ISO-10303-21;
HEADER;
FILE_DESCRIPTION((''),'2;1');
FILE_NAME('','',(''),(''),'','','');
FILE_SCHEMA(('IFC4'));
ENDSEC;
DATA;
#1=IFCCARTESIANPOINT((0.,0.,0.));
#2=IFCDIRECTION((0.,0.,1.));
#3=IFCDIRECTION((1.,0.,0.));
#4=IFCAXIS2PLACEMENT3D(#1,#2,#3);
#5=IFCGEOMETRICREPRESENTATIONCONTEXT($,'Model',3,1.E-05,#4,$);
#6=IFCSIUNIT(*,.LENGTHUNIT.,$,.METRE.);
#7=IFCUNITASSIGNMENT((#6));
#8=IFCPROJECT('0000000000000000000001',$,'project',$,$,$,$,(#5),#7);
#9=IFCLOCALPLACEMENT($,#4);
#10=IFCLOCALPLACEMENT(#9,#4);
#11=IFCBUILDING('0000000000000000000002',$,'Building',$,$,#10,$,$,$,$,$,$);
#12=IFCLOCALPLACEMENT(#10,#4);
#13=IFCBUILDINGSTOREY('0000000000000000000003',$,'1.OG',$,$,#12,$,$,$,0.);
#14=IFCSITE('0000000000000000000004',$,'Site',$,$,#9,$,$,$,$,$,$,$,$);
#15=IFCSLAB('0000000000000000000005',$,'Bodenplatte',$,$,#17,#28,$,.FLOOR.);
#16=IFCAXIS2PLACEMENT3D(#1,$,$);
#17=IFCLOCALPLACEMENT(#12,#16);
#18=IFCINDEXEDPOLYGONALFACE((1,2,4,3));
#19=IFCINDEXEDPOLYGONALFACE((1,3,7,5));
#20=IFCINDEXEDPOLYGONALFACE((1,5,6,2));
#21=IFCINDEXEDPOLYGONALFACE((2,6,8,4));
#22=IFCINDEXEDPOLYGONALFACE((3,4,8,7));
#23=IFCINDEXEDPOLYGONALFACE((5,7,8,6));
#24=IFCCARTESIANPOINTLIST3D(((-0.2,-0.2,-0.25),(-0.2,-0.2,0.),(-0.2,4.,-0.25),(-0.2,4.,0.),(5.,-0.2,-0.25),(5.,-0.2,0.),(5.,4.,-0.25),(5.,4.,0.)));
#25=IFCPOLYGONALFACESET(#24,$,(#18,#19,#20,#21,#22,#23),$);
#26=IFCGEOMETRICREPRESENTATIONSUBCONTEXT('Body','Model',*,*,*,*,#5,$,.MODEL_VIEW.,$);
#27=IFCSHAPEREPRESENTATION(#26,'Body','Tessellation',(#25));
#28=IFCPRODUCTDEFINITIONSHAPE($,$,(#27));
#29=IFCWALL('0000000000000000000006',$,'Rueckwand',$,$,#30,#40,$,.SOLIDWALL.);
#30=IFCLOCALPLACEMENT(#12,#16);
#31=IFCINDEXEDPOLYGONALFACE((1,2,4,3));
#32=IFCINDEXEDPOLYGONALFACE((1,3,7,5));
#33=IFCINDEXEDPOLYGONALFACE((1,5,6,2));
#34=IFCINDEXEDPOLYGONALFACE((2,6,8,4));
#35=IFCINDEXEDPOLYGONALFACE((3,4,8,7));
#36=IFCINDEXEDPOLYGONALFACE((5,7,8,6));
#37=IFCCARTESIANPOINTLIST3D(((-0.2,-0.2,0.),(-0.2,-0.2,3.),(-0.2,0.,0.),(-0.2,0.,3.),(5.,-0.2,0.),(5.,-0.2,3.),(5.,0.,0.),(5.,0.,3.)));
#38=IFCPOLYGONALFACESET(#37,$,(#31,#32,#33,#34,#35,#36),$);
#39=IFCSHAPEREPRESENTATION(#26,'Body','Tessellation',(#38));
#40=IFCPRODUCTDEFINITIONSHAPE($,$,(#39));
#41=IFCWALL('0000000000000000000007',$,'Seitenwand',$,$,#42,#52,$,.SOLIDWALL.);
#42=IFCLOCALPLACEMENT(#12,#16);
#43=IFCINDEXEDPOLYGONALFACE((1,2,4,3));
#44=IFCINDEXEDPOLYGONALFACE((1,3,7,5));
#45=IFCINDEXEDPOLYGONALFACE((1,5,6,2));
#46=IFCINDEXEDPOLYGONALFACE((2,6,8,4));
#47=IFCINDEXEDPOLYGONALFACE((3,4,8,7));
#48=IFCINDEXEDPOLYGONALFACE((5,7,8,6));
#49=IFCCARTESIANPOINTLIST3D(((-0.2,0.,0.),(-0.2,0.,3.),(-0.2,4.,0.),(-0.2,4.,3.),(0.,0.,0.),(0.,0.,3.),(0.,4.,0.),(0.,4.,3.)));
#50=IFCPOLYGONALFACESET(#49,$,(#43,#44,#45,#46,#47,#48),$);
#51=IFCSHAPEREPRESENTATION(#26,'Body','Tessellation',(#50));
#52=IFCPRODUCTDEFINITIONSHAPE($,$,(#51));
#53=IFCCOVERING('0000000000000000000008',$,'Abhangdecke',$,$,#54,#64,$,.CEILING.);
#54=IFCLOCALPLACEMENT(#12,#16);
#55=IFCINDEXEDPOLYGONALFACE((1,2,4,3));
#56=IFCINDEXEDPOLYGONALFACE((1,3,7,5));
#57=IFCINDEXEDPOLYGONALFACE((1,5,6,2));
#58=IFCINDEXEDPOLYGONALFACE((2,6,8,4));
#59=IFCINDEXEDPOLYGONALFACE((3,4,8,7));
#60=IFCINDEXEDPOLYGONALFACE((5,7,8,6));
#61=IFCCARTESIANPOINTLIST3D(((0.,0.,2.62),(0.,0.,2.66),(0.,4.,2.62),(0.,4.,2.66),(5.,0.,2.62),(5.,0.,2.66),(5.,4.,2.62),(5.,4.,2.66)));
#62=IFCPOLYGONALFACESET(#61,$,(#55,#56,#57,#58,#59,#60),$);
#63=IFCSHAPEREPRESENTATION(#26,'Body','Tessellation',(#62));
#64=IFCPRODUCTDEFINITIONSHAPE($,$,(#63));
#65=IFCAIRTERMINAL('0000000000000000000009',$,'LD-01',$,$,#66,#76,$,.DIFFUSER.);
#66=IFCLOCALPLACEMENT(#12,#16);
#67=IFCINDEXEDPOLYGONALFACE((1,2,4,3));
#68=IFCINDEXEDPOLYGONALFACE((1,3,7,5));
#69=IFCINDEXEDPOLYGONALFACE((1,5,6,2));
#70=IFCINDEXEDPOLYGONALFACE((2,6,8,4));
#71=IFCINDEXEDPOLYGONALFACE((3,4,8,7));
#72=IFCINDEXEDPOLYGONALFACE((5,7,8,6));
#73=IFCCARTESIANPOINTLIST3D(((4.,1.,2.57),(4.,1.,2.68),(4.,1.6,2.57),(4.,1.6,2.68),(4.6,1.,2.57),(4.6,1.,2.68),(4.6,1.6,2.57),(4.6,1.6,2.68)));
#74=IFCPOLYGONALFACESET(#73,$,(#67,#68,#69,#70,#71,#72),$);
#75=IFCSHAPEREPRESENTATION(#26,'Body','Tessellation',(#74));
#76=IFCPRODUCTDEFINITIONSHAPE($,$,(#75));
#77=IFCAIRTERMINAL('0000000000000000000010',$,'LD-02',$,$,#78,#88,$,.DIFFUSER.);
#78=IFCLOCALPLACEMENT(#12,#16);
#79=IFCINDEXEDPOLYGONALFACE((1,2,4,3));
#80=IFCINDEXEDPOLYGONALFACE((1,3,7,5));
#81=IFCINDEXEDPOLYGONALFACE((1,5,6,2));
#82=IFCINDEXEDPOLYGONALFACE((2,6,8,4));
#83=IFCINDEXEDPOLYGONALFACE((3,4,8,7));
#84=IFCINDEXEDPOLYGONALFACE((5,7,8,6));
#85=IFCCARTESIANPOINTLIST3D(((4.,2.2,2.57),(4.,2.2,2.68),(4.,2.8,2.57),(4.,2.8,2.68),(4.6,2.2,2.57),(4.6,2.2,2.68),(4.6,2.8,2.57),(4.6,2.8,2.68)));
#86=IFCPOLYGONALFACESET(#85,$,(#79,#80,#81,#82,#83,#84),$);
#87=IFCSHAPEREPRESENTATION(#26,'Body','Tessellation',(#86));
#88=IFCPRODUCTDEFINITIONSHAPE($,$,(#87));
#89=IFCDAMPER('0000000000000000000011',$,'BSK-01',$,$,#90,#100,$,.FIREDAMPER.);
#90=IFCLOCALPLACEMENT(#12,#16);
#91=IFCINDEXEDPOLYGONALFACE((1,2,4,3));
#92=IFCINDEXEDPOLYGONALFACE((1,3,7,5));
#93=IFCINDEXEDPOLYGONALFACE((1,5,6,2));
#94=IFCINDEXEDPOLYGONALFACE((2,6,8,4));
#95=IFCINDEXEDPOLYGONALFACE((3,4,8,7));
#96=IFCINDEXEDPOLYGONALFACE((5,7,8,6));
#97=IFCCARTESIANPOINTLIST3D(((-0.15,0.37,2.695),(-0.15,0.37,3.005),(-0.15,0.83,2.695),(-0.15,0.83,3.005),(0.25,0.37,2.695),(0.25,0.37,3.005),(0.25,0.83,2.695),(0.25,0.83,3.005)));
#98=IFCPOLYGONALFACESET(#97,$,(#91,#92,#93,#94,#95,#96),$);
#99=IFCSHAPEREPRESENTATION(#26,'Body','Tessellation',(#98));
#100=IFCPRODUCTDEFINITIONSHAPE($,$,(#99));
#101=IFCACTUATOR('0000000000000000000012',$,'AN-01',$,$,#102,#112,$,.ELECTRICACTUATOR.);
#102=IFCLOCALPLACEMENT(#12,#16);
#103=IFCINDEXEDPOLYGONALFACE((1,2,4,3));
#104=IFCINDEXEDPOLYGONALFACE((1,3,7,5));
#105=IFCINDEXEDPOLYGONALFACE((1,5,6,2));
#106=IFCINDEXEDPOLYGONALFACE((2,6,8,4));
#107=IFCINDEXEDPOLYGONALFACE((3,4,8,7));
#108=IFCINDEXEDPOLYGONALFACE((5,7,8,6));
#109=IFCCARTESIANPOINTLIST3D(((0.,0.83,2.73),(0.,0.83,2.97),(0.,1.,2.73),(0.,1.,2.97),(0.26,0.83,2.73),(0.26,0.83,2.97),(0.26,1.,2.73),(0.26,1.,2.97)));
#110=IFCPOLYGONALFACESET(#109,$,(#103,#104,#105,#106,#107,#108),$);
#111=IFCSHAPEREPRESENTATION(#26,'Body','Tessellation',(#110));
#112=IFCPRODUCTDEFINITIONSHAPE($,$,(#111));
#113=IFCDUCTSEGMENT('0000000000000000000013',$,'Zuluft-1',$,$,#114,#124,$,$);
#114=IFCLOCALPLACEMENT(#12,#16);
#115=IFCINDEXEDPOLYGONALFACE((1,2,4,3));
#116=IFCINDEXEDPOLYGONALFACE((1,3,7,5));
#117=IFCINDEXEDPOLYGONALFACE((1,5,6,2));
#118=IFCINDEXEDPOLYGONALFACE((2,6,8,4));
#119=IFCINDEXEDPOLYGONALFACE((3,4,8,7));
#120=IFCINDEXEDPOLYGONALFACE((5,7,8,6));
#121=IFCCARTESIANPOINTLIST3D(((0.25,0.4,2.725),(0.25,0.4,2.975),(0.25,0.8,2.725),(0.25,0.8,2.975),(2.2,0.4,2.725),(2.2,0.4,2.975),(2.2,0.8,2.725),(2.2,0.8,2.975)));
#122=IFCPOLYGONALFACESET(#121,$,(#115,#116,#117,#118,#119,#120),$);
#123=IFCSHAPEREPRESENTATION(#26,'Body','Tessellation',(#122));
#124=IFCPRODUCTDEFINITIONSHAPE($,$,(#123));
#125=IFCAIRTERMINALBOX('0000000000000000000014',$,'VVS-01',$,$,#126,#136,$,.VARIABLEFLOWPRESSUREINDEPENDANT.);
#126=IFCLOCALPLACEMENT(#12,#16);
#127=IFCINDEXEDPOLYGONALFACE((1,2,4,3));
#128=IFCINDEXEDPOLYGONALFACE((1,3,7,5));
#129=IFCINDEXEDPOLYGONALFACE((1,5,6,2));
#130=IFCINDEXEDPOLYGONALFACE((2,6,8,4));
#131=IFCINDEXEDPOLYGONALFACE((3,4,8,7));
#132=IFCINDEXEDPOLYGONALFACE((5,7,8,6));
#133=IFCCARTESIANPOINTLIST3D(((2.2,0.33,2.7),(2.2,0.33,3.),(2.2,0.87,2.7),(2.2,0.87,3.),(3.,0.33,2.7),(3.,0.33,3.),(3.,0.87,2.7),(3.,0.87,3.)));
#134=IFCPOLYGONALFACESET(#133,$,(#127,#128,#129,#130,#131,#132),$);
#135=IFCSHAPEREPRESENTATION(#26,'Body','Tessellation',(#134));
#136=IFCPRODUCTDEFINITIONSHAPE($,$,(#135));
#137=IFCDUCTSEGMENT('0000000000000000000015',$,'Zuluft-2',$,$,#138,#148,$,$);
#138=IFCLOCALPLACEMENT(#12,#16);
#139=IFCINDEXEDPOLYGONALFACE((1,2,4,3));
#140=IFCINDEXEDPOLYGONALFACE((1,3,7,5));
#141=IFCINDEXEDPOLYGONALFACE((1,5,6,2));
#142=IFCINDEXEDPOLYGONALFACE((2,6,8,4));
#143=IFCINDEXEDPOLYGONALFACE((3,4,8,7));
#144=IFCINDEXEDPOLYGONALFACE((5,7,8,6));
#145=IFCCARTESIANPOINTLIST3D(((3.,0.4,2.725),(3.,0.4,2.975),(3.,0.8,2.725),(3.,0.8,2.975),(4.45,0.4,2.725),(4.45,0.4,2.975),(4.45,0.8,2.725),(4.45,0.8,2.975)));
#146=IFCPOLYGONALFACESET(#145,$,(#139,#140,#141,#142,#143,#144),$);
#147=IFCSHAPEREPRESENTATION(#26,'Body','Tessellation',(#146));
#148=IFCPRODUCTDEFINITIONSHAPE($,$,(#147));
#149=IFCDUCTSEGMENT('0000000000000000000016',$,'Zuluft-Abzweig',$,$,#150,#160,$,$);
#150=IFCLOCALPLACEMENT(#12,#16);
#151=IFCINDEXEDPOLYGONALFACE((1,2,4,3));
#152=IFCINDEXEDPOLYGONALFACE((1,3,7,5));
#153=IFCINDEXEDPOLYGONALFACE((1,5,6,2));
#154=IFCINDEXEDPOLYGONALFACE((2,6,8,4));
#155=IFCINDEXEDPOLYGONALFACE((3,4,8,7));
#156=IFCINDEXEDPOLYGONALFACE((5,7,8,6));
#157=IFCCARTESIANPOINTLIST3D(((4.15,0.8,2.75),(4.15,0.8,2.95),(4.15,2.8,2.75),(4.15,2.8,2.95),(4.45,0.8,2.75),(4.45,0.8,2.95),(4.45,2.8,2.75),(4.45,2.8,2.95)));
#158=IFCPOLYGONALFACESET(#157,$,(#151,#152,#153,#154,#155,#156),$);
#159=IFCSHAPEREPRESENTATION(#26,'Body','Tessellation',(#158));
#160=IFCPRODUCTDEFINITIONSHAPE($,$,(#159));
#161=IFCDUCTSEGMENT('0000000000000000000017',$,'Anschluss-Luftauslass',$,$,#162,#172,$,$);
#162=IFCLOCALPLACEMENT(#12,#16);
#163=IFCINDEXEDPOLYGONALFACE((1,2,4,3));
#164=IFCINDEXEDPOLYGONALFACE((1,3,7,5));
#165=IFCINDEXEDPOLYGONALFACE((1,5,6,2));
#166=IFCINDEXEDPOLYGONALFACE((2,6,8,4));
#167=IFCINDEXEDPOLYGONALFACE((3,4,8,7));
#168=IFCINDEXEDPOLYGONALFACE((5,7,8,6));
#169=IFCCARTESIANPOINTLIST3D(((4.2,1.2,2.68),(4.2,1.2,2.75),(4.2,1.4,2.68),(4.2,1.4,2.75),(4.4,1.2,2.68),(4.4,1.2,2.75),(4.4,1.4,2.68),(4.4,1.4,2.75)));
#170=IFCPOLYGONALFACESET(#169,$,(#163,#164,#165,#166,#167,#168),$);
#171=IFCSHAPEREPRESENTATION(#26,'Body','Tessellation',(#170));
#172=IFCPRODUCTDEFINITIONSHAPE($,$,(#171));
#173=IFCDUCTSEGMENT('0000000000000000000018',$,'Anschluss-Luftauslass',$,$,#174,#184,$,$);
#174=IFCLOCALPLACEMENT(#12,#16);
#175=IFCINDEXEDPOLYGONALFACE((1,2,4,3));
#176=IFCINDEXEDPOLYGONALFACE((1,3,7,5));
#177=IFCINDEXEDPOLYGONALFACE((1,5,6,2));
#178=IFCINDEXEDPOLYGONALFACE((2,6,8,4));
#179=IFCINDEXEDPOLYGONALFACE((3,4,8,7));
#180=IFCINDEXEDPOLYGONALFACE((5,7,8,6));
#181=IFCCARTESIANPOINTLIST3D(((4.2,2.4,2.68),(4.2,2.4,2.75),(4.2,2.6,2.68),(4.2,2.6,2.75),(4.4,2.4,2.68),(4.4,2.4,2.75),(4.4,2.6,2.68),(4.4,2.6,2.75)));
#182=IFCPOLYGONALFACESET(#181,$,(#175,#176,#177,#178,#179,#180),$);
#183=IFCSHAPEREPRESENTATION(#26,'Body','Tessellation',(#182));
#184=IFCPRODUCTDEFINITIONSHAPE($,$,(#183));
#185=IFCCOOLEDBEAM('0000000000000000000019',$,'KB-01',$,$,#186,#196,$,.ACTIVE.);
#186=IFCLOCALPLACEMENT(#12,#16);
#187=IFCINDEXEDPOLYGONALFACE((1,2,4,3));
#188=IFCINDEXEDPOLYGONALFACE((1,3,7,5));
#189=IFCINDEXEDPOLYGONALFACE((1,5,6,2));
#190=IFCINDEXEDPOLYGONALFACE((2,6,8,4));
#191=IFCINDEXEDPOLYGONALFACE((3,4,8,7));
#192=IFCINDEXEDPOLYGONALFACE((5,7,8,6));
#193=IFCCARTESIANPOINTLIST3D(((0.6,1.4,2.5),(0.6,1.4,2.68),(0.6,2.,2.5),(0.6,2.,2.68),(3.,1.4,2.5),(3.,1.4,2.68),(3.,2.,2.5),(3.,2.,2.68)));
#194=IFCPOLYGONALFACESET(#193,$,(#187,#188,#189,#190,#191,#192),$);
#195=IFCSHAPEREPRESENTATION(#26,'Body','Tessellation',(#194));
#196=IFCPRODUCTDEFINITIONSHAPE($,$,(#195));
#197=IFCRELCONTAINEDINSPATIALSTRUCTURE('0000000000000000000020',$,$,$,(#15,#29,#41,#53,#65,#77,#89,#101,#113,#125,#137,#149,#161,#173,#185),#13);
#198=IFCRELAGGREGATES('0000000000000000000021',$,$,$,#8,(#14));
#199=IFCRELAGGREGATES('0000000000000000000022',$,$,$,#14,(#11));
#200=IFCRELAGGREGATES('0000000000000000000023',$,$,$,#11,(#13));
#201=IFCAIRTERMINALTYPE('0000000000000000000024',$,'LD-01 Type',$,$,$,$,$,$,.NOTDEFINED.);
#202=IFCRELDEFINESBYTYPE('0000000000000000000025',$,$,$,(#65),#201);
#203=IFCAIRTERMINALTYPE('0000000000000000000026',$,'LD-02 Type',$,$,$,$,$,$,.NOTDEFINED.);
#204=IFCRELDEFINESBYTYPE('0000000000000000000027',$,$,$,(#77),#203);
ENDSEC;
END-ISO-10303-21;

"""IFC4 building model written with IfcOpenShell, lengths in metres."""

from ifc_helpers import new_model, si_unit, frame, origin_with_axes, place, context, subcontext, project, spatial, polyline, outline, extrude, type_object, element, save


model = new_model("IFC4")

# Units and contexts
model_context = context("Model", 3, precision=1e-05, world=origin_with_axes())
body_context = subcontext(model_context, "Body", "Model", "MODEL_VIEW")
ifc_project = project(units=[si_unit("LENGTHUNIT", "METRE")], contexts=[model_context])

# Site, building, storey
site_placement = place(None, origin_with_axes())
site = spatial("IfcSite", under=ifc_project, at=site_placement, Name="Site")
building_placement = place(site_placement, origin_with_axes())
building = spatial("IfcBuilding", under=site, at=building_placement, Name="Building")
storey_placement = place(building_placement, origin_with_axes())
storey = spatial("IfcBuildingStorey", under=building, at=storey_placement, Name="1.OG", Elevation=0.0)

# Slab
slab_placement = place(storey_placement, frame((0.0, 0.0, -0.25), z_axis=(0.0, 0.0, 1.0), x_axis=(1.0, 0.0, 0.0)))
element("IfcSlab", 1, at=slab_placement, inside=storey, Name="Bodenplatte", PredefinedType="FLOOR", context=body_context, shape_type="SweptSolid", body=[
    extrude(outline(polyline([(-0.2, -0.2, 0.0), (5.0, -0.2, 0.0), (5.0, 4.0, 0.0), (-0.2, 4.0, 0.0), (-0.2, -0.2, 0.0)])), origin_with_axes(), (0.0, 0.0, 1.0), 0.25),
])

# Walls
wall_1_placement = place(storey_placement, frame((-0.2, -0.2, 0.0), z_axis=(0.0, 0.0, 1.0), x_axis=(1.0, 0.0, 0.0)))
element("IfcWall", 2, at=wall_1_placement, inside=storey, Name="Rueckwand", PredefinedType="SOLIDWALL", context=body_context, shape_type="SweptSolid", body=[
    extrude(outline(polyline([(0.0, 0.0, 0.0), (5.2, 0.0, 0.0), (5.2, 0.2, 0.0), (0.0, 0.2, 0.0), (0.0, 0.0, 0.0)])), origin_with_axes(), (0.0, 0.0, 1.0), 3.0),
])
wall_2_placement = place(storey_placement, frame((0.0, 0.0, 0.0), z_axis=(0.0, 0.0, 1.0), x_axis=(0.0, 1.0, 0.0)))
element("IfcWall", 3, at=wall_2_placement, inside=storey, Name="Seitenwand", PredefinedType="SOLIDWALL", context=body_context, shape_type="SweptSolid", body=[
    extrude(outline(polyline([(0.0, 0.0, 0.0), (4.0, 0.0, 0.0), (4.0, 0.2, 0.0), (0.0, 0.2, 0.0), (0.0, 0.0, 0.0)])), origin_with_axes(), (0.0, 0.0, 1.0), 3.0),
])

# Covering
covering_placement = place(storey_placement, frame((0.0, 0.0, 2.62), z_axis=(0.0, 0.0, 1.0), x_axis=(1.0, 0.0, 0.0)))
element("IfcCovering", 4, at=covering_placement, inside=storey, Name="Abhangdecke", PredefinedType="CEILING", context=body_context, shape_type="SweptSolid", body=[
    extrude(outline(polyline([(0.0, 0.0, 0.0), (5.0, 0.0, 0.0), (5.0, 4.0, 0.0), (0.0, 4.0, 0.0), (0.0, 0.0, 0.0)])), origin_with_axes(), (0.0, 0.0, 1.0), 0.04),
])

# Air terminals
air_terminal_type_1 = type_object("IfcAirTerminalType", Name="LD-01 Type", PredefinedType="NOTDEFINED")
air_terminal_1_placement = place(storey_placement, origin_with_axes())
element("IfcAirTerminal", 5, at=air_terminal_1_placement, inside=storey, type_object=air_terminal_type_1, Name="LD-01", PredefinedType="DIFFUSER", context=body_context, shape_type="SweptSolid", body=[
    extrude(outline(polyline([(4.0, 1.0, 0.0), (4.6, 1.0, 0.0), (4.6, 1.6, 0.0), (4.0, 1.6, 0.0), (4.0, 1.0, 0.0)])), frame((0.0, 0.0, 2.57), z_axis=(0.0, 0.0, 1.0), x_axis=(1.0, 0.0, 0.0)), (0.0, 0.0, 1.0), 0.11),
])
air_terminal_type_2 = type_object("IfcAirTerminalType", Name="LD-02 Type", PredefinedType="NOTDEFINED")
air_terminal_2_placement = place(storey_placement, origin_with_axes())
element("IfcAirTerminal", 6, at=air_terminal_2_placement, inside=storey, type_object=air_terminal_type_2, Name="LD-02", PredefinedType="DIFFUSER", context=body_context, shape_type="SweptSolid", body=[
    extrude(outline(polyline([(4.0, 2.2, 0.0), (4.6, 2.2, 0.0), (4.6, 2.8, 0.0), (4.0, 2.8, 0.0), (4.0, 2.2, 0.0)])), frame((0.0, 0.0, 2.57), z_axis=(0.0, 0.0, 1.0), x_axis=(1.0, 0.0, 0.0)), (0.0, 0.0, 1.0), 0.11),
])

# Damper
damper_placement = place(storey_placement, origin_with_axes())
element("IfcDamper", 7, at=damper_placement, inside=storey, Name="BSK-01", PredefinedType="FIREDAMPER", context=body_context, shape_type="SweptSolid", body=[
    extrude(outline(polyline([(-0.15, 0.37, 0.0), (0.25, 0.37, 0.0), (0.25, 0.83, 0.0), (-0.15, 0.83, 0.0), (-0.15, 0.37, 0.0)])), frame((0.0, 0.0, 2.695), z_axis=(0.0, 0.0, 1.0), x_axis=(1.0, 0.0, 0.0)), (0.0, 0.0, 1.0), 0.31),
])

# Actuator
actuator_placement = place(storey_placement, origin_with_axes())
element("IfcActuator", 8, at=actuator_placement, inside=storey, Name="AN-01", PredefinedType="ELECTRICACTUATOR", context=body_context, shape_type="SweptSolid", body=[
    extrude(outline(polyline([(0.0, 0.83, 0.0), (0.26, 0.83, 0.0), (0.26, 1.0, 0.0), (0.0, 1.0, 0.0), (0.0, 0.83, 0.0)])), frame((0.0, 0.0, 2.73), z_axis=(0.0, 0.0, 1.0), x_axis=(1.0, 0.0, 0.0)), (0.0, 0.0, 1.0), 0.24),
])

# Duct segment
duct_segment_1_placement = place(storey_placement, origin_with_axes())
element("IfcDuctSegment", 9, at=duct_segment_1_placement, inside=storey, Name="Zuluft-1", context=body_context, shape_type="SweptSolid", body=[
    extrude(outline(polyline([(-0.2, -0.125, 0.0), (0.2, -0.125, 0.0), (0.2, 0.125, 0.0), (-0.2, 0.125, 0.0), (-0.2, -0.125, 0.0)])), frame((0.25, 0.6, 2.85), z_axis=(1.0, 0.0, 0.0), x_axis=(0.0, 1.0, 0.0)), (0.0, 0.0, 1.0), 1.95),
])

# Air terminal box
air_terminal_box_placement = place(storey_placement, origin_with_axes())
element("IfcAirTerminalBox", 10, at=air_terminal_box_placement, inside=storey, Name="VVS-01", PredefinedType="VARIABLEFLOWPRESSUREINDEPENDANT", context=body_context, shape_type="SweptSolid", body=[
    extrude(outline(polyline([(2.2, 0.33, 0.0), (3.0, 0.33, 0.0), (3.0, 0.87, 0.0), (2.2, 0.87, 0.0), (2.2, 0.33, 0.0)])), frame((0.0, 0.0, 2.7), z_axis=(0.0, 0.0, 1.0), x_axis=(1.0, 0.0, 0.0)), (0.0, 0.0, 1.0), 0.3),
])

# Duct segments
duct_segment_2_placement = place(storey_placement, origin_with_axes())
element("IfcDuctSegment", 11, at=duct_segment_2_placement, inside=storey, Name="Zuluft-2", context=body_context, shape_type="SweptSolid", body=[
    extrude(outline(polyline([(-0.2, -0.125, 0.0), (0.2, -0.125, 0.0), (0.2, 0.125, 0.0), (-0.2, 0.125, 0.0), (-0.2, -0.125, 0.0)])), frame((3.0, 0.6, 2.85), z_axis=(1.0, 0.0, 0.0), x_axis=(0.0, 1.0, 0.0)), (0.0, 0.0, 1.0), 1.45),
])
duct_segment_3_placement = place(storey_placement, origin_with_axes())
element("IfcDuctSegment", 12, at=duct_segment_3_placement, inside=storey, Name="Zuluft-Abzweig", context=body_context, shape_type="SweptSolid", body=[
    extrude(outline(polyline([(-0.15, -0.1, 0.0), (0.15, -0.1, 0.0), (0.15, 0.1, 0.0), (-0.15, 0.1, 0.0), (-0.15, -0.1, 0.0)])), frame((4.3, 0.8, 2.85), z_axis=(0.0, 1.0, 0.0), x_axis=(-1.0, 0.0, 0.0)), (0.0, 0.0, 1.0), 2.0),
])
duct_segment_4_placement = place(storey_placement, origin_with_axes())
element("IfcDuctSegment", 13, at=duct_segment_4_placement, inside=storey, Name="Anschluss-Luftauslass", context=body_context, shape_type="SweptSolid", body=[
    extrude(outline(polyline([(-0.1, -0.1, 0.0), (0.1, -0.1, 0.0), (0.1, 0.1, 0.0), (-0.1, 0.1, 0.0), (-0.1, -0.1, 0.0)])), frame((4.3, 1.3, 2.68), z_axis=(0.0, 0.0, 1.0), x_axis=(1.0, 0.0, 0.0)), (0.0, 0.0, 1.0), 0.07),
])
duct_segment_5_placement = place(storey_placement, origin_with_axes())
element("IfcDuctSegment", 14, at=duct_segment_5_placement, inside=storey, Name="Anschluss-Luftauslass", context=body_context, shape_type="SweptSolid", body=[
    extrude(outline(polyline([(-0.1, -0.1, 0.0), (0.1, -0.1, 0.0), (0.1, 0.1, 0.0), (-0.1, 0.1, 0.0), (-0.1, -0.1, 0.0)])), frame((4.3, 2.5, 2.68), z_axis=(0.0, 0.0, 1.0), x_axis=(1.0, 0.0, 0.0)), (0.0, 0.0, 1.0), 0.07),
])

# Cooled beam
cooled_beam_placement = place(storey_placement, origin_with_axes())
element("IfcCooledBeam", 15, at=cooled_beam_placement, inside=storey, Name="KB-01", PredefinedType="ACTIVE", context=body_context, shape_type="SweptSolid", body=[
    extrude(outline(polyline([(0.6, 1.4, 0.0), (3.0, 1.4, 0.0), (3.0, 2.0, 0.0), (0.6, 2.0, 0.0), (0.6, 1.4, 0.0)])), frame((0.0, 0.0, 2.5), z_axis=(0.0, 0.0, 1.0), x_axis=(1.0, 0.0, 0.0)), (0.0, 0.0, 1.0), 0.18),
])

save(model, "model.ifc")
